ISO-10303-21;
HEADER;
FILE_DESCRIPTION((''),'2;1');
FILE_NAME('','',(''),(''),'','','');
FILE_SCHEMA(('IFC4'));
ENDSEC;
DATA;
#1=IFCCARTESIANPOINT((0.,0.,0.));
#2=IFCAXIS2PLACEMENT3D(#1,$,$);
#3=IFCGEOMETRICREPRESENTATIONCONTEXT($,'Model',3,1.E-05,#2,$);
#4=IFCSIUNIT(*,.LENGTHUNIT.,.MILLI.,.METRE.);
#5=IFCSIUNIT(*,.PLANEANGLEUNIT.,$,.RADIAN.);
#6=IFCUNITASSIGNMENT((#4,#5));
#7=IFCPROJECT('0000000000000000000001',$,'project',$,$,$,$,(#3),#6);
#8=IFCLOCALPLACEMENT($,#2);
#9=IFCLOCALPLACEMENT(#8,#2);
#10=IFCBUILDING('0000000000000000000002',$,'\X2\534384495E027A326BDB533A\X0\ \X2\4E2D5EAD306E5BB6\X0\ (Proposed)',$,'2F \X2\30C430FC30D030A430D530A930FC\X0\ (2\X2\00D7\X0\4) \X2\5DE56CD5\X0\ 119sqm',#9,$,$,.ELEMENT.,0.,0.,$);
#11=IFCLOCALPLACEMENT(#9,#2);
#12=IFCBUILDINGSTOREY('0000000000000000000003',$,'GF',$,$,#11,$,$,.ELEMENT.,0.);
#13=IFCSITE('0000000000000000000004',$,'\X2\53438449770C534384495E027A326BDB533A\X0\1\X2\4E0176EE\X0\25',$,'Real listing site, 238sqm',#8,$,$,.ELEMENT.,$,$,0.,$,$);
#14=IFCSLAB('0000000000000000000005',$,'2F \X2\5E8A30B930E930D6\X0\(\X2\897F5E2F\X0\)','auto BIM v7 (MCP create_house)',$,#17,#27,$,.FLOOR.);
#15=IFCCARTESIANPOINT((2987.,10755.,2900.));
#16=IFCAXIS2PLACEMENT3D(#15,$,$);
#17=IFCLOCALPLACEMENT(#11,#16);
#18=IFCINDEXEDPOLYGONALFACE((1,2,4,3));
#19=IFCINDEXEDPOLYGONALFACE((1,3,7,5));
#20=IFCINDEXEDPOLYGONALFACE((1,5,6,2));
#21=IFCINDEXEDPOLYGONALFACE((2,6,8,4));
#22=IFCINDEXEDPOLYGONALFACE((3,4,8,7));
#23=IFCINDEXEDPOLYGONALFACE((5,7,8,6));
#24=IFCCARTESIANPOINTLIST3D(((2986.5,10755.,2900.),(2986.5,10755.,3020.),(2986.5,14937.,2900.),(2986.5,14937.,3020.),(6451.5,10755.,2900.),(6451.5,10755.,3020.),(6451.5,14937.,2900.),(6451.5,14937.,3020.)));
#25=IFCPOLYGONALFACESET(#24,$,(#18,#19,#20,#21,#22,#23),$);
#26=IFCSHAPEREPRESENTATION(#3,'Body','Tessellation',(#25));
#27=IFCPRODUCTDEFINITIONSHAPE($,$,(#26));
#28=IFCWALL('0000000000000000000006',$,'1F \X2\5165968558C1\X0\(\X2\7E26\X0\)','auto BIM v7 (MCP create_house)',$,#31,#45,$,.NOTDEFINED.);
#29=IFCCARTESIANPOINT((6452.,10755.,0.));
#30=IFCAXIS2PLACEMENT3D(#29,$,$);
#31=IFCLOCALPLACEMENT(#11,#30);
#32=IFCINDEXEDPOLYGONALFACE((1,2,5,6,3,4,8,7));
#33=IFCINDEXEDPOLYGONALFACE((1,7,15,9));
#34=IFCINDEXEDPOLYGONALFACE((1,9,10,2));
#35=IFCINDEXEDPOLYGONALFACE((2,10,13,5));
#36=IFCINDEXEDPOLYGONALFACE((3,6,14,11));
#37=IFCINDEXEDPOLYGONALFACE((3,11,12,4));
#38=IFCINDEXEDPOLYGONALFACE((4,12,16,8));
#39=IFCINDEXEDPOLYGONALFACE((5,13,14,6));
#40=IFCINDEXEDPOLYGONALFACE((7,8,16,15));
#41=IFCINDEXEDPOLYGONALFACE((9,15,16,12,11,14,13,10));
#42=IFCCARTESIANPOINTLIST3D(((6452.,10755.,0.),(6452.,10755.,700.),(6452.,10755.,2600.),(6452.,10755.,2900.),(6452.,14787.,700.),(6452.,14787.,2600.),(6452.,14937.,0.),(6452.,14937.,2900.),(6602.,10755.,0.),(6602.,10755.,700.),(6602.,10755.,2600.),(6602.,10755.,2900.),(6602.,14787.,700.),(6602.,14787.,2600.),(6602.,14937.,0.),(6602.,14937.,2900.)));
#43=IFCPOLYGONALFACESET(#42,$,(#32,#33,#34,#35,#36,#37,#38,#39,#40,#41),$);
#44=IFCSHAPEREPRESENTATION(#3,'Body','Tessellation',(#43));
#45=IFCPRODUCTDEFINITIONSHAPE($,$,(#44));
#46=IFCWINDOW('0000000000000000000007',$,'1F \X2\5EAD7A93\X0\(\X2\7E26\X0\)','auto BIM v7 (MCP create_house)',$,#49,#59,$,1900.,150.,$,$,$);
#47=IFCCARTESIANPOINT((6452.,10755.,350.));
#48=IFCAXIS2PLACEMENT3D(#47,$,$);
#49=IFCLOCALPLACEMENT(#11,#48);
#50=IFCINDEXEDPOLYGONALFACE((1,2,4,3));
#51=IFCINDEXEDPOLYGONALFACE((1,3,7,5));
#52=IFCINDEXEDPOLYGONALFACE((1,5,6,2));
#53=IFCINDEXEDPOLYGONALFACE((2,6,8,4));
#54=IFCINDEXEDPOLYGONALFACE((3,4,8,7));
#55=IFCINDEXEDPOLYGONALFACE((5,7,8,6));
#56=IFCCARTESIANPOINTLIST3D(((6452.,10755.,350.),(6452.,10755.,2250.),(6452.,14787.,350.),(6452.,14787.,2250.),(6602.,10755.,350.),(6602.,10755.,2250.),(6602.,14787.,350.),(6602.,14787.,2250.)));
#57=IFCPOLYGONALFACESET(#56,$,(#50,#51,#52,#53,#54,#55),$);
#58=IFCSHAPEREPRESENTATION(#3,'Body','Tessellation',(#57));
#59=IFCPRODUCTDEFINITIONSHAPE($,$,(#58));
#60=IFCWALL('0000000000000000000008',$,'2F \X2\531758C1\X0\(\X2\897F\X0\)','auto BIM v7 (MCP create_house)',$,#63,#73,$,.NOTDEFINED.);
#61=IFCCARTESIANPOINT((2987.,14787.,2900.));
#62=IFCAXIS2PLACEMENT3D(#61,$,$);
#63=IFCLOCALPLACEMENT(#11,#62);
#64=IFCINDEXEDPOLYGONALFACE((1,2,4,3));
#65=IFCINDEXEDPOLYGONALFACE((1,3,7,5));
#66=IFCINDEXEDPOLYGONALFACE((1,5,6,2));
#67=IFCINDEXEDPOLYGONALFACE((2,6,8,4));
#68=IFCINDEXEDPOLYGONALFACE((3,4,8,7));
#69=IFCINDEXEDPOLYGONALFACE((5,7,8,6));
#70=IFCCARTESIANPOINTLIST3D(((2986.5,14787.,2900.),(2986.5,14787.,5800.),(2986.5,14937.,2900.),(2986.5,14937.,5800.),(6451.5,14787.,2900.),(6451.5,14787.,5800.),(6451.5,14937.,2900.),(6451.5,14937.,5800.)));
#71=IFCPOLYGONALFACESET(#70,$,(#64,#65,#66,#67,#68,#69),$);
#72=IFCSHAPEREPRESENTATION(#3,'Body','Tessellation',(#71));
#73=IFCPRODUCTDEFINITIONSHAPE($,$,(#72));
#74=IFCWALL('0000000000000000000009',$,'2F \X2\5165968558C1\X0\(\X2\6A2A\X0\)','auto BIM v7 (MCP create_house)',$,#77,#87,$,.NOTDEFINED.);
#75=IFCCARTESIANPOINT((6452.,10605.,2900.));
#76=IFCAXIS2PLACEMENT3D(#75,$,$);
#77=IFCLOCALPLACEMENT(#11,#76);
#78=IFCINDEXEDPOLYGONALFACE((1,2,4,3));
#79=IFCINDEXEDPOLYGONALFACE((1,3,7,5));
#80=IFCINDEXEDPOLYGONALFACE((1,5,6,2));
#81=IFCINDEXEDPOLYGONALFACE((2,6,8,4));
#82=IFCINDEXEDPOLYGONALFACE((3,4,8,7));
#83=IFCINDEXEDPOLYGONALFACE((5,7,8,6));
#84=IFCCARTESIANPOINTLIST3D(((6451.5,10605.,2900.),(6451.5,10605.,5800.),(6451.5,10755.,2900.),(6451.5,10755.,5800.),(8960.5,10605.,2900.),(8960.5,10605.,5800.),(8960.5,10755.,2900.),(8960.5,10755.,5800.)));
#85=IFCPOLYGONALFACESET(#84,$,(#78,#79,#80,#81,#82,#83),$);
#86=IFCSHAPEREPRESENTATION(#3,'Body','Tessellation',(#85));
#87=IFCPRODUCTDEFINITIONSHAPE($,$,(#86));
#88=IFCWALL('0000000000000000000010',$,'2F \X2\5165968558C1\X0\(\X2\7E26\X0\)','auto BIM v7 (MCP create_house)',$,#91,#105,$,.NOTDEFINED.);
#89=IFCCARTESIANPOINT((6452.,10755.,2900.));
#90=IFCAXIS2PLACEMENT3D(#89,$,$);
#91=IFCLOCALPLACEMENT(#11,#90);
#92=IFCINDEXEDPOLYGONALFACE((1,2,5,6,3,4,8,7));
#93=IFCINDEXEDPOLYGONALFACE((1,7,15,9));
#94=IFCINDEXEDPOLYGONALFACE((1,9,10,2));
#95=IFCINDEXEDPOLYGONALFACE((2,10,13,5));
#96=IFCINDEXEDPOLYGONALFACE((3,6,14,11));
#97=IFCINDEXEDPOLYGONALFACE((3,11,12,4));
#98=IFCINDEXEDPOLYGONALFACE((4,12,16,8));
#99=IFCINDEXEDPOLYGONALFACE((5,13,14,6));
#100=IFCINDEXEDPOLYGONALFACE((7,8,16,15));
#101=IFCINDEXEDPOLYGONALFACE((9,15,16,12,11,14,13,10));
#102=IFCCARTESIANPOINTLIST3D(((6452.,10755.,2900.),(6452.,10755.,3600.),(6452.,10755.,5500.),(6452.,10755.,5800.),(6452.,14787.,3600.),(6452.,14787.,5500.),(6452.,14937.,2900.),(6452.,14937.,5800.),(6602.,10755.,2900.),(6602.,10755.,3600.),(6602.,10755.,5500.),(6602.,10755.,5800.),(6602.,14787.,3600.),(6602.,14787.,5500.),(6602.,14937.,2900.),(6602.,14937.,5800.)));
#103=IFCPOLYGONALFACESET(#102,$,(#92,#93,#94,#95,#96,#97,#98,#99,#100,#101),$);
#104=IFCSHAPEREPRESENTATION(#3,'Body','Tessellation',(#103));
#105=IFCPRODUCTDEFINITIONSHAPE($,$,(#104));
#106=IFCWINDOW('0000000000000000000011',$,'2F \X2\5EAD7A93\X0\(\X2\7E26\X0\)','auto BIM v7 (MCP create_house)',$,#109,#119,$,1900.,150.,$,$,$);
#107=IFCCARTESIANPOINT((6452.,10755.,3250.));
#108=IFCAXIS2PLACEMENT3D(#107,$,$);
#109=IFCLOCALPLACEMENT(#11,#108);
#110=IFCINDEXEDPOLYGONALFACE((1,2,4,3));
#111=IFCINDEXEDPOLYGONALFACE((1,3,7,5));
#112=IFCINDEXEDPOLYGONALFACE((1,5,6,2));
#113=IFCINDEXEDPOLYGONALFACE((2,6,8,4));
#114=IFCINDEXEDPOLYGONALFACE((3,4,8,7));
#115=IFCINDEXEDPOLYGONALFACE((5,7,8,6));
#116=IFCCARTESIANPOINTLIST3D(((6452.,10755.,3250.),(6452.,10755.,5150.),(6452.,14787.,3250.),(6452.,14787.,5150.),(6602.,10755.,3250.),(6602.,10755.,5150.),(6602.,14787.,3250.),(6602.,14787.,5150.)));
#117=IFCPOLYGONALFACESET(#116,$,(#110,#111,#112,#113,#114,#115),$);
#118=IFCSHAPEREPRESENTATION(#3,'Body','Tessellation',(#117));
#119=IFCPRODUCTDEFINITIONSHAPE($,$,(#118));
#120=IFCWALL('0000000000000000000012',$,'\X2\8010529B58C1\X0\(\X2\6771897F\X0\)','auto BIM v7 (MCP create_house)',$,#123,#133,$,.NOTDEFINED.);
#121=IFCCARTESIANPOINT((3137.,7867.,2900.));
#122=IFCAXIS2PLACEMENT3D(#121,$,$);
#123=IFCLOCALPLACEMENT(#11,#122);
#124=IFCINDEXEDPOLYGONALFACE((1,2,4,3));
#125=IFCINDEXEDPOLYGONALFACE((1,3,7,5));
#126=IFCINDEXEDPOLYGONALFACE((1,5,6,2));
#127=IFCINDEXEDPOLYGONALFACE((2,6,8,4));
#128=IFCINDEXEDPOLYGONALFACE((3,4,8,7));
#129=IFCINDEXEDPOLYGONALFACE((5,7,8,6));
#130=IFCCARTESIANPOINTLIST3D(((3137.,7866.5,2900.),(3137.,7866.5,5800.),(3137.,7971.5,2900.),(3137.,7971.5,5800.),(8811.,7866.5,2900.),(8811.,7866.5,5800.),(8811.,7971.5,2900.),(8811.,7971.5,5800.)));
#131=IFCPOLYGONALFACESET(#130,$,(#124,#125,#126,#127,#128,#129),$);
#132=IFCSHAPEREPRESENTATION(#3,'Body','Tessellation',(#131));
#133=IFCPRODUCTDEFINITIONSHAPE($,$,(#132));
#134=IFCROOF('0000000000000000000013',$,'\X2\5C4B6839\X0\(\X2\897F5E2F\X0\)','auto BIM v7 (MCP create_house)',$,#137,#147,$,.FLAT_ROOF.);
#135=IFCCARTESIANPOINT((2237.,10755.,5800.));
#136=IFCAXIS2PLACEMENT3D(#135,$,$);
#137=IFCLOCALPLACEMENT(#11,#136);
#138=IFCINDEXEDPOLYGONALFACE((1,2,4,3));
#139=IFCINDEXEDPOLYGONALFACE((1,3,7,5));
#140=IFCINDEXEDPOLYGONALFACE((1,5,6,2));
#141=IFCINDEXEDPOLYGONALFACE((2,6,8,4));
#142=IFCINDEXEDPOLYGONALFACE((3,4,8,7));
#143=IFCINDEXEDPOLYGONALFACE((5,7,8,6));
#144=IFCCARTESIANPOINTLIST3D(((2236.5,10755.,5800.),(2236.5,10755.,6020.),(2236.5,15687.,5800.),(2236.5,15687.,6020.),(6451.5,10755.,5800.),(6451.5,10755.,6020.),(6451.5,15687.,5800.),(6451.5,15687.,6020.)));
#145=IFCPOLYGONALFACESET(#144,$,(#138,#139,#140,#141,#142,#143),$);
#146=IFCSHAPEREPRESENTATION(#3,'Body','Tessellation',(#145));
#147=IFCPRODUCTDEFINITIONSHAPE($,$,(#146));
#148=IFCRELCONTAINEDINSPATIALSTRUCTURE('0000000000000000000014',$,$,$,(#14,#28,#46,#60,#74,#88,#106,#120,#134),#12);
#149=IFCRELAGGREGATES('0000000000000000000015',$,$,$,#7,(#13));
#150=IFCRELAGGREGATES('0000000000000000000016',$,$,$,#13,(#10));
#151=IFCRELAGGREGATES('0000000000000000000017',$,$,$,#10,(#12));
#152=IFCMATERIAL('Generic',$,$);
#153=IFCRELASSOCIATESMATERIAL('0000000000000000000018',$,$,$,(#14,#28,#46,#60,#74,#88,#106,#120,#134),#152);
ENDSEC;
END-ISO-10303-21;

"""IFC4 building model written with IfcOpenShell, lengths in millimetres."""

from ifc_helpers import new_model, si_unit, frame, frame_2d, origin, place, context, project, spatial, rectangle, extrude, material, element, fill, save


model = new_model("IFC4")

# Units and contexts
model_context = context("Model", 3, precision=1e-05, world=origin())
ifc_project = project(units=[si_unit("LENGTHUNIT", "METRE", prefix="MILLI"), si_unit("PLANEANGLEUNIT", "RADIAN")], contexts=[model_context])

# Site, building, storey
site_placement = place(None, origin())
site = spatial("IfcSite", under=ifc_project, at=site_placement, Name="千葉県千葉市稲毛区1丁目25", ObjectType="Real listing site, 238sqm", CompositionType="ELEMENT", RefElevation=0.0)
building_placement = place(site_placement, origin())
building = spatial("IfcBuilding", under=site, at=building_placement, Name="千葉市稲毛区 中庭の家 (Proposed)", ObjectType="2F ツーバイフォー (2×4) 工法 119sqm", CompositionType="ELEMENT", ElevationOfRefHeight=0.0, ElevationOfTerrain=0.0)
storey_placement = place(building_placement, origin())
storey = spatial("IfcBuildingStorey", under=building, at=storey_placement, Name="GF", CompositionType="ELEMENT", Elevation=0.0)

# Slab
ifc_material = material(Name="Generic")
slab_1_placement = place(storey_placement, frame((2987.0, 10755.0, 2900.0)))
element("IfcSlab", 1, at=slab_1_placement, inside=storey, material=ifc_material, Name="2F 床スラブ(西帯)", Description="auto BIM v7 (MCP create_house)", PredefinedType="FLOOR", context=model_context, shape_type="SweptSolid", body=[
    extrude(rectangle(XDim=3465.0, YDim=4182.0, at=frame_2d((1732.0, 2091.0))), frame((2987.0, 10755.0, 2900.0)), (0.0, 0.0, 1.0), 120.0),
])

# Wall, opening, window
wall_1_placement = place(storey_placement, frame((6452.0, 10755.0, 0.0)))
wall_1 = element("IfcWall", 2, at=wall_1_placement, inside=storey, material=ifc_material, Name="1F 入隅壁(縦)", Description="auto BIM v7 (MCP create_house)", PredefinedType="NOTDEFINED", context=model_context, shape_type="SweptSolid", body=[
    extrude(rectangle(XDim=150.0, YDim=4182.0, at=frame_2d((75.0, 2091.0))), frame((6452.0, 10755.0, 0.0)), (0.0, 0.0, 1.0), 2900.0),
])
opening_1_placement = place(storey_placement, frame((6452.0, 10755.0, 350.0)))
opening_1 = element("IfcOpeningElement", 3, at=opening_1_placement, cuts=wall_1, PredefinedType="NOTDEFINED", context=model_context, shape_type="SweptSolid", body=[
    extrude(rectangle(XDim=150.0, YDim=4032.0, at=frame_2d((75.0, 2016.0))), frame((6452.0, 10755.0, 350.0)), (0.0, 0.0, 1.0), 1900.0),
])
window_1_placement = place(storey_placement, frame((6452.0, 10755.0, 350.0)))
window_1 = element("IfcWindow", 4, at=window_1_placement, inside=storey, material=ifc_material, Name="1F 庭窓(縦)", Description="auto BIM v7 (MCP create_house)", OverallHeight=1900.0, OverallWidth=150.0, context=model_context, shape_type="SweptSolid", body=[
    extrude(rectangle(XDim=150.0, YDim=4032.0, at=frame_2d((75.0, 2016.0))), frame((6452.0, 10755.0, 350.0)), (0.0, 0.0, 1.0), 1900.0),
])
fill(opening_1, window_1)

# Walls
wall_2_placement = place(storey_placement, frame((2987.0, 14787.0, 2900.0)))
element("IfcWall", 5, at=wall_2_placement, inside=storey, material=ifc_material, Name="2F 北壁(西)", Description="auto BIM v7 (MCP create_house)", PredefinedType="NOTDEFINED", context=model_context, shape_type="SweptSolid", body=[
    extrude(rectangle(XDim=3465.0, YDim=150.0, at=frame_2d((1732.0, 75.0))), frame((2987.0, 14787.0, 2900.0)), (0.0, 0.0, 1.0), 2900.0),
])
wall_3_placement = place(storey_placement, frame((6452.0, 10605.0, 2900.0)))
element("IfcWall", 6, at=wall_3_placement, inside=storey, material=ifc_material, Name="2F 入隅壁(横)", Description="auto BIM v7 (MCP create_house)", PredefinedType="NOTDEFINED", context=model_context, shape_type="SweptSolid", body=[
    extrude(rectangle(XDim=2509.0, YDim=150.0, at=frame_2d((1254.0, 75.0))), frame((6452.0, 10605.0, 2900.0)), (0.0, 0.0, 1.0), 2900.0),
])

# Wall, opening, window
wall_4_placement = place(storey_placement, frame((6452.0, 10755.0, 2900.0)))
wall_4 = element("IfcWall", 7, at=wall_4_placement, inside=storey, material=ifc_material, Name="2F 入隅壁(縦)", Description="auto BIM v7 (MCP create_house)", PredefinedType="NOTDEFINED", context=model_context, shape_type="SweptSolid", body=[
    extrude(rectangle(XDim=150.0, YDim=4182.0, at=frame_2d((75.0, 2091.0))), frame((6452.0, 10755.0, 2900.0)), (0.0, 0.0, 1.0), 2900.0),
])
opening_2_placement = place(storey_placement, frame((6452.0, 10755.0, 3250.0)))
opening_2 = element("IfcOpeningElement", 8, at=opening_2_placement, cuts=wall_4, PredefinedType="NOTDEFINED", context=model_context, shape_type="SweptSolid", body=[
    extrude(rectangle(XDim=150.0, YDim=4032.0, at=frame_2d((75.0, 2016.0))), frame((6452.0, 10755.0, 3250.0)), (0.0, 0.0, 1.0), 1900.0),
])
window_2_placement = place(storey_placement, frame((6452.0, 10755.0, 3250.0)))
window_2 = element("IfcWindow", 9, at=window_2_placement, inside=storey, material=ifc_material, Name="2F 庭窓(縦)", Description="auto BIM v7 (MCP create_house)", OverallHeight=1900.0, OverallWidth=150.0, context=model_context, shape_type="SweptSolid", body=[
    extrude(rectangle(XDim=150.0, YDim=4032.0, at=frame_2d((75.0, 2016.0))), frame((6452.0, 10755.0, 3250.0)), (0.0, 0.0, 1.0), 1900.0),
])
fill(opening_2, window_2)

# Wall
wall_5_placement = place(storey_placement, frame((3137.0, 7867.0, 2900.0)))
element("IfcWall", 10, at=wall_5_placement, inside=storey, material=ifc_material, Name="耐力壁(東西)", Description="auto BIM v7 (MCP create_house)", PredefinedType="NOTDEFINED", context=model_context, shape_type="SweptSolid", body=[
    extrude(rectangle(XDim=5674.0, YDim=105.0, at=frame_2d((2837.0, 52.0))), frame((3137.0, 7867.0, 2900.0)), (0.0, 0.0, 1.0), 2900.0),
])

# Roof
for number, where, name in (
    (11, (2237.0, 10755.0, 5800.0), "屋根(西帯)"),
):
    element("IfcRoof", number, at=place(storey_placement, frame(where)), inside=storey, material=ifc_material, Name=name, Description="auto BIM v7 (MCP create_house)", PredefinedType="FLAT_ROOF", context=model_context, shape_type="SweptSolid", body=[
        extrude(rectangle(XDim=4215.0, YDim=4932.0, at=frame_2d((2107.0, 2466.0))), frame((2237.0, 10755.0, 5800.0)), (0.0, 0.0, 1.0), 220.0),
    ])

save(model, "model.ifc")
